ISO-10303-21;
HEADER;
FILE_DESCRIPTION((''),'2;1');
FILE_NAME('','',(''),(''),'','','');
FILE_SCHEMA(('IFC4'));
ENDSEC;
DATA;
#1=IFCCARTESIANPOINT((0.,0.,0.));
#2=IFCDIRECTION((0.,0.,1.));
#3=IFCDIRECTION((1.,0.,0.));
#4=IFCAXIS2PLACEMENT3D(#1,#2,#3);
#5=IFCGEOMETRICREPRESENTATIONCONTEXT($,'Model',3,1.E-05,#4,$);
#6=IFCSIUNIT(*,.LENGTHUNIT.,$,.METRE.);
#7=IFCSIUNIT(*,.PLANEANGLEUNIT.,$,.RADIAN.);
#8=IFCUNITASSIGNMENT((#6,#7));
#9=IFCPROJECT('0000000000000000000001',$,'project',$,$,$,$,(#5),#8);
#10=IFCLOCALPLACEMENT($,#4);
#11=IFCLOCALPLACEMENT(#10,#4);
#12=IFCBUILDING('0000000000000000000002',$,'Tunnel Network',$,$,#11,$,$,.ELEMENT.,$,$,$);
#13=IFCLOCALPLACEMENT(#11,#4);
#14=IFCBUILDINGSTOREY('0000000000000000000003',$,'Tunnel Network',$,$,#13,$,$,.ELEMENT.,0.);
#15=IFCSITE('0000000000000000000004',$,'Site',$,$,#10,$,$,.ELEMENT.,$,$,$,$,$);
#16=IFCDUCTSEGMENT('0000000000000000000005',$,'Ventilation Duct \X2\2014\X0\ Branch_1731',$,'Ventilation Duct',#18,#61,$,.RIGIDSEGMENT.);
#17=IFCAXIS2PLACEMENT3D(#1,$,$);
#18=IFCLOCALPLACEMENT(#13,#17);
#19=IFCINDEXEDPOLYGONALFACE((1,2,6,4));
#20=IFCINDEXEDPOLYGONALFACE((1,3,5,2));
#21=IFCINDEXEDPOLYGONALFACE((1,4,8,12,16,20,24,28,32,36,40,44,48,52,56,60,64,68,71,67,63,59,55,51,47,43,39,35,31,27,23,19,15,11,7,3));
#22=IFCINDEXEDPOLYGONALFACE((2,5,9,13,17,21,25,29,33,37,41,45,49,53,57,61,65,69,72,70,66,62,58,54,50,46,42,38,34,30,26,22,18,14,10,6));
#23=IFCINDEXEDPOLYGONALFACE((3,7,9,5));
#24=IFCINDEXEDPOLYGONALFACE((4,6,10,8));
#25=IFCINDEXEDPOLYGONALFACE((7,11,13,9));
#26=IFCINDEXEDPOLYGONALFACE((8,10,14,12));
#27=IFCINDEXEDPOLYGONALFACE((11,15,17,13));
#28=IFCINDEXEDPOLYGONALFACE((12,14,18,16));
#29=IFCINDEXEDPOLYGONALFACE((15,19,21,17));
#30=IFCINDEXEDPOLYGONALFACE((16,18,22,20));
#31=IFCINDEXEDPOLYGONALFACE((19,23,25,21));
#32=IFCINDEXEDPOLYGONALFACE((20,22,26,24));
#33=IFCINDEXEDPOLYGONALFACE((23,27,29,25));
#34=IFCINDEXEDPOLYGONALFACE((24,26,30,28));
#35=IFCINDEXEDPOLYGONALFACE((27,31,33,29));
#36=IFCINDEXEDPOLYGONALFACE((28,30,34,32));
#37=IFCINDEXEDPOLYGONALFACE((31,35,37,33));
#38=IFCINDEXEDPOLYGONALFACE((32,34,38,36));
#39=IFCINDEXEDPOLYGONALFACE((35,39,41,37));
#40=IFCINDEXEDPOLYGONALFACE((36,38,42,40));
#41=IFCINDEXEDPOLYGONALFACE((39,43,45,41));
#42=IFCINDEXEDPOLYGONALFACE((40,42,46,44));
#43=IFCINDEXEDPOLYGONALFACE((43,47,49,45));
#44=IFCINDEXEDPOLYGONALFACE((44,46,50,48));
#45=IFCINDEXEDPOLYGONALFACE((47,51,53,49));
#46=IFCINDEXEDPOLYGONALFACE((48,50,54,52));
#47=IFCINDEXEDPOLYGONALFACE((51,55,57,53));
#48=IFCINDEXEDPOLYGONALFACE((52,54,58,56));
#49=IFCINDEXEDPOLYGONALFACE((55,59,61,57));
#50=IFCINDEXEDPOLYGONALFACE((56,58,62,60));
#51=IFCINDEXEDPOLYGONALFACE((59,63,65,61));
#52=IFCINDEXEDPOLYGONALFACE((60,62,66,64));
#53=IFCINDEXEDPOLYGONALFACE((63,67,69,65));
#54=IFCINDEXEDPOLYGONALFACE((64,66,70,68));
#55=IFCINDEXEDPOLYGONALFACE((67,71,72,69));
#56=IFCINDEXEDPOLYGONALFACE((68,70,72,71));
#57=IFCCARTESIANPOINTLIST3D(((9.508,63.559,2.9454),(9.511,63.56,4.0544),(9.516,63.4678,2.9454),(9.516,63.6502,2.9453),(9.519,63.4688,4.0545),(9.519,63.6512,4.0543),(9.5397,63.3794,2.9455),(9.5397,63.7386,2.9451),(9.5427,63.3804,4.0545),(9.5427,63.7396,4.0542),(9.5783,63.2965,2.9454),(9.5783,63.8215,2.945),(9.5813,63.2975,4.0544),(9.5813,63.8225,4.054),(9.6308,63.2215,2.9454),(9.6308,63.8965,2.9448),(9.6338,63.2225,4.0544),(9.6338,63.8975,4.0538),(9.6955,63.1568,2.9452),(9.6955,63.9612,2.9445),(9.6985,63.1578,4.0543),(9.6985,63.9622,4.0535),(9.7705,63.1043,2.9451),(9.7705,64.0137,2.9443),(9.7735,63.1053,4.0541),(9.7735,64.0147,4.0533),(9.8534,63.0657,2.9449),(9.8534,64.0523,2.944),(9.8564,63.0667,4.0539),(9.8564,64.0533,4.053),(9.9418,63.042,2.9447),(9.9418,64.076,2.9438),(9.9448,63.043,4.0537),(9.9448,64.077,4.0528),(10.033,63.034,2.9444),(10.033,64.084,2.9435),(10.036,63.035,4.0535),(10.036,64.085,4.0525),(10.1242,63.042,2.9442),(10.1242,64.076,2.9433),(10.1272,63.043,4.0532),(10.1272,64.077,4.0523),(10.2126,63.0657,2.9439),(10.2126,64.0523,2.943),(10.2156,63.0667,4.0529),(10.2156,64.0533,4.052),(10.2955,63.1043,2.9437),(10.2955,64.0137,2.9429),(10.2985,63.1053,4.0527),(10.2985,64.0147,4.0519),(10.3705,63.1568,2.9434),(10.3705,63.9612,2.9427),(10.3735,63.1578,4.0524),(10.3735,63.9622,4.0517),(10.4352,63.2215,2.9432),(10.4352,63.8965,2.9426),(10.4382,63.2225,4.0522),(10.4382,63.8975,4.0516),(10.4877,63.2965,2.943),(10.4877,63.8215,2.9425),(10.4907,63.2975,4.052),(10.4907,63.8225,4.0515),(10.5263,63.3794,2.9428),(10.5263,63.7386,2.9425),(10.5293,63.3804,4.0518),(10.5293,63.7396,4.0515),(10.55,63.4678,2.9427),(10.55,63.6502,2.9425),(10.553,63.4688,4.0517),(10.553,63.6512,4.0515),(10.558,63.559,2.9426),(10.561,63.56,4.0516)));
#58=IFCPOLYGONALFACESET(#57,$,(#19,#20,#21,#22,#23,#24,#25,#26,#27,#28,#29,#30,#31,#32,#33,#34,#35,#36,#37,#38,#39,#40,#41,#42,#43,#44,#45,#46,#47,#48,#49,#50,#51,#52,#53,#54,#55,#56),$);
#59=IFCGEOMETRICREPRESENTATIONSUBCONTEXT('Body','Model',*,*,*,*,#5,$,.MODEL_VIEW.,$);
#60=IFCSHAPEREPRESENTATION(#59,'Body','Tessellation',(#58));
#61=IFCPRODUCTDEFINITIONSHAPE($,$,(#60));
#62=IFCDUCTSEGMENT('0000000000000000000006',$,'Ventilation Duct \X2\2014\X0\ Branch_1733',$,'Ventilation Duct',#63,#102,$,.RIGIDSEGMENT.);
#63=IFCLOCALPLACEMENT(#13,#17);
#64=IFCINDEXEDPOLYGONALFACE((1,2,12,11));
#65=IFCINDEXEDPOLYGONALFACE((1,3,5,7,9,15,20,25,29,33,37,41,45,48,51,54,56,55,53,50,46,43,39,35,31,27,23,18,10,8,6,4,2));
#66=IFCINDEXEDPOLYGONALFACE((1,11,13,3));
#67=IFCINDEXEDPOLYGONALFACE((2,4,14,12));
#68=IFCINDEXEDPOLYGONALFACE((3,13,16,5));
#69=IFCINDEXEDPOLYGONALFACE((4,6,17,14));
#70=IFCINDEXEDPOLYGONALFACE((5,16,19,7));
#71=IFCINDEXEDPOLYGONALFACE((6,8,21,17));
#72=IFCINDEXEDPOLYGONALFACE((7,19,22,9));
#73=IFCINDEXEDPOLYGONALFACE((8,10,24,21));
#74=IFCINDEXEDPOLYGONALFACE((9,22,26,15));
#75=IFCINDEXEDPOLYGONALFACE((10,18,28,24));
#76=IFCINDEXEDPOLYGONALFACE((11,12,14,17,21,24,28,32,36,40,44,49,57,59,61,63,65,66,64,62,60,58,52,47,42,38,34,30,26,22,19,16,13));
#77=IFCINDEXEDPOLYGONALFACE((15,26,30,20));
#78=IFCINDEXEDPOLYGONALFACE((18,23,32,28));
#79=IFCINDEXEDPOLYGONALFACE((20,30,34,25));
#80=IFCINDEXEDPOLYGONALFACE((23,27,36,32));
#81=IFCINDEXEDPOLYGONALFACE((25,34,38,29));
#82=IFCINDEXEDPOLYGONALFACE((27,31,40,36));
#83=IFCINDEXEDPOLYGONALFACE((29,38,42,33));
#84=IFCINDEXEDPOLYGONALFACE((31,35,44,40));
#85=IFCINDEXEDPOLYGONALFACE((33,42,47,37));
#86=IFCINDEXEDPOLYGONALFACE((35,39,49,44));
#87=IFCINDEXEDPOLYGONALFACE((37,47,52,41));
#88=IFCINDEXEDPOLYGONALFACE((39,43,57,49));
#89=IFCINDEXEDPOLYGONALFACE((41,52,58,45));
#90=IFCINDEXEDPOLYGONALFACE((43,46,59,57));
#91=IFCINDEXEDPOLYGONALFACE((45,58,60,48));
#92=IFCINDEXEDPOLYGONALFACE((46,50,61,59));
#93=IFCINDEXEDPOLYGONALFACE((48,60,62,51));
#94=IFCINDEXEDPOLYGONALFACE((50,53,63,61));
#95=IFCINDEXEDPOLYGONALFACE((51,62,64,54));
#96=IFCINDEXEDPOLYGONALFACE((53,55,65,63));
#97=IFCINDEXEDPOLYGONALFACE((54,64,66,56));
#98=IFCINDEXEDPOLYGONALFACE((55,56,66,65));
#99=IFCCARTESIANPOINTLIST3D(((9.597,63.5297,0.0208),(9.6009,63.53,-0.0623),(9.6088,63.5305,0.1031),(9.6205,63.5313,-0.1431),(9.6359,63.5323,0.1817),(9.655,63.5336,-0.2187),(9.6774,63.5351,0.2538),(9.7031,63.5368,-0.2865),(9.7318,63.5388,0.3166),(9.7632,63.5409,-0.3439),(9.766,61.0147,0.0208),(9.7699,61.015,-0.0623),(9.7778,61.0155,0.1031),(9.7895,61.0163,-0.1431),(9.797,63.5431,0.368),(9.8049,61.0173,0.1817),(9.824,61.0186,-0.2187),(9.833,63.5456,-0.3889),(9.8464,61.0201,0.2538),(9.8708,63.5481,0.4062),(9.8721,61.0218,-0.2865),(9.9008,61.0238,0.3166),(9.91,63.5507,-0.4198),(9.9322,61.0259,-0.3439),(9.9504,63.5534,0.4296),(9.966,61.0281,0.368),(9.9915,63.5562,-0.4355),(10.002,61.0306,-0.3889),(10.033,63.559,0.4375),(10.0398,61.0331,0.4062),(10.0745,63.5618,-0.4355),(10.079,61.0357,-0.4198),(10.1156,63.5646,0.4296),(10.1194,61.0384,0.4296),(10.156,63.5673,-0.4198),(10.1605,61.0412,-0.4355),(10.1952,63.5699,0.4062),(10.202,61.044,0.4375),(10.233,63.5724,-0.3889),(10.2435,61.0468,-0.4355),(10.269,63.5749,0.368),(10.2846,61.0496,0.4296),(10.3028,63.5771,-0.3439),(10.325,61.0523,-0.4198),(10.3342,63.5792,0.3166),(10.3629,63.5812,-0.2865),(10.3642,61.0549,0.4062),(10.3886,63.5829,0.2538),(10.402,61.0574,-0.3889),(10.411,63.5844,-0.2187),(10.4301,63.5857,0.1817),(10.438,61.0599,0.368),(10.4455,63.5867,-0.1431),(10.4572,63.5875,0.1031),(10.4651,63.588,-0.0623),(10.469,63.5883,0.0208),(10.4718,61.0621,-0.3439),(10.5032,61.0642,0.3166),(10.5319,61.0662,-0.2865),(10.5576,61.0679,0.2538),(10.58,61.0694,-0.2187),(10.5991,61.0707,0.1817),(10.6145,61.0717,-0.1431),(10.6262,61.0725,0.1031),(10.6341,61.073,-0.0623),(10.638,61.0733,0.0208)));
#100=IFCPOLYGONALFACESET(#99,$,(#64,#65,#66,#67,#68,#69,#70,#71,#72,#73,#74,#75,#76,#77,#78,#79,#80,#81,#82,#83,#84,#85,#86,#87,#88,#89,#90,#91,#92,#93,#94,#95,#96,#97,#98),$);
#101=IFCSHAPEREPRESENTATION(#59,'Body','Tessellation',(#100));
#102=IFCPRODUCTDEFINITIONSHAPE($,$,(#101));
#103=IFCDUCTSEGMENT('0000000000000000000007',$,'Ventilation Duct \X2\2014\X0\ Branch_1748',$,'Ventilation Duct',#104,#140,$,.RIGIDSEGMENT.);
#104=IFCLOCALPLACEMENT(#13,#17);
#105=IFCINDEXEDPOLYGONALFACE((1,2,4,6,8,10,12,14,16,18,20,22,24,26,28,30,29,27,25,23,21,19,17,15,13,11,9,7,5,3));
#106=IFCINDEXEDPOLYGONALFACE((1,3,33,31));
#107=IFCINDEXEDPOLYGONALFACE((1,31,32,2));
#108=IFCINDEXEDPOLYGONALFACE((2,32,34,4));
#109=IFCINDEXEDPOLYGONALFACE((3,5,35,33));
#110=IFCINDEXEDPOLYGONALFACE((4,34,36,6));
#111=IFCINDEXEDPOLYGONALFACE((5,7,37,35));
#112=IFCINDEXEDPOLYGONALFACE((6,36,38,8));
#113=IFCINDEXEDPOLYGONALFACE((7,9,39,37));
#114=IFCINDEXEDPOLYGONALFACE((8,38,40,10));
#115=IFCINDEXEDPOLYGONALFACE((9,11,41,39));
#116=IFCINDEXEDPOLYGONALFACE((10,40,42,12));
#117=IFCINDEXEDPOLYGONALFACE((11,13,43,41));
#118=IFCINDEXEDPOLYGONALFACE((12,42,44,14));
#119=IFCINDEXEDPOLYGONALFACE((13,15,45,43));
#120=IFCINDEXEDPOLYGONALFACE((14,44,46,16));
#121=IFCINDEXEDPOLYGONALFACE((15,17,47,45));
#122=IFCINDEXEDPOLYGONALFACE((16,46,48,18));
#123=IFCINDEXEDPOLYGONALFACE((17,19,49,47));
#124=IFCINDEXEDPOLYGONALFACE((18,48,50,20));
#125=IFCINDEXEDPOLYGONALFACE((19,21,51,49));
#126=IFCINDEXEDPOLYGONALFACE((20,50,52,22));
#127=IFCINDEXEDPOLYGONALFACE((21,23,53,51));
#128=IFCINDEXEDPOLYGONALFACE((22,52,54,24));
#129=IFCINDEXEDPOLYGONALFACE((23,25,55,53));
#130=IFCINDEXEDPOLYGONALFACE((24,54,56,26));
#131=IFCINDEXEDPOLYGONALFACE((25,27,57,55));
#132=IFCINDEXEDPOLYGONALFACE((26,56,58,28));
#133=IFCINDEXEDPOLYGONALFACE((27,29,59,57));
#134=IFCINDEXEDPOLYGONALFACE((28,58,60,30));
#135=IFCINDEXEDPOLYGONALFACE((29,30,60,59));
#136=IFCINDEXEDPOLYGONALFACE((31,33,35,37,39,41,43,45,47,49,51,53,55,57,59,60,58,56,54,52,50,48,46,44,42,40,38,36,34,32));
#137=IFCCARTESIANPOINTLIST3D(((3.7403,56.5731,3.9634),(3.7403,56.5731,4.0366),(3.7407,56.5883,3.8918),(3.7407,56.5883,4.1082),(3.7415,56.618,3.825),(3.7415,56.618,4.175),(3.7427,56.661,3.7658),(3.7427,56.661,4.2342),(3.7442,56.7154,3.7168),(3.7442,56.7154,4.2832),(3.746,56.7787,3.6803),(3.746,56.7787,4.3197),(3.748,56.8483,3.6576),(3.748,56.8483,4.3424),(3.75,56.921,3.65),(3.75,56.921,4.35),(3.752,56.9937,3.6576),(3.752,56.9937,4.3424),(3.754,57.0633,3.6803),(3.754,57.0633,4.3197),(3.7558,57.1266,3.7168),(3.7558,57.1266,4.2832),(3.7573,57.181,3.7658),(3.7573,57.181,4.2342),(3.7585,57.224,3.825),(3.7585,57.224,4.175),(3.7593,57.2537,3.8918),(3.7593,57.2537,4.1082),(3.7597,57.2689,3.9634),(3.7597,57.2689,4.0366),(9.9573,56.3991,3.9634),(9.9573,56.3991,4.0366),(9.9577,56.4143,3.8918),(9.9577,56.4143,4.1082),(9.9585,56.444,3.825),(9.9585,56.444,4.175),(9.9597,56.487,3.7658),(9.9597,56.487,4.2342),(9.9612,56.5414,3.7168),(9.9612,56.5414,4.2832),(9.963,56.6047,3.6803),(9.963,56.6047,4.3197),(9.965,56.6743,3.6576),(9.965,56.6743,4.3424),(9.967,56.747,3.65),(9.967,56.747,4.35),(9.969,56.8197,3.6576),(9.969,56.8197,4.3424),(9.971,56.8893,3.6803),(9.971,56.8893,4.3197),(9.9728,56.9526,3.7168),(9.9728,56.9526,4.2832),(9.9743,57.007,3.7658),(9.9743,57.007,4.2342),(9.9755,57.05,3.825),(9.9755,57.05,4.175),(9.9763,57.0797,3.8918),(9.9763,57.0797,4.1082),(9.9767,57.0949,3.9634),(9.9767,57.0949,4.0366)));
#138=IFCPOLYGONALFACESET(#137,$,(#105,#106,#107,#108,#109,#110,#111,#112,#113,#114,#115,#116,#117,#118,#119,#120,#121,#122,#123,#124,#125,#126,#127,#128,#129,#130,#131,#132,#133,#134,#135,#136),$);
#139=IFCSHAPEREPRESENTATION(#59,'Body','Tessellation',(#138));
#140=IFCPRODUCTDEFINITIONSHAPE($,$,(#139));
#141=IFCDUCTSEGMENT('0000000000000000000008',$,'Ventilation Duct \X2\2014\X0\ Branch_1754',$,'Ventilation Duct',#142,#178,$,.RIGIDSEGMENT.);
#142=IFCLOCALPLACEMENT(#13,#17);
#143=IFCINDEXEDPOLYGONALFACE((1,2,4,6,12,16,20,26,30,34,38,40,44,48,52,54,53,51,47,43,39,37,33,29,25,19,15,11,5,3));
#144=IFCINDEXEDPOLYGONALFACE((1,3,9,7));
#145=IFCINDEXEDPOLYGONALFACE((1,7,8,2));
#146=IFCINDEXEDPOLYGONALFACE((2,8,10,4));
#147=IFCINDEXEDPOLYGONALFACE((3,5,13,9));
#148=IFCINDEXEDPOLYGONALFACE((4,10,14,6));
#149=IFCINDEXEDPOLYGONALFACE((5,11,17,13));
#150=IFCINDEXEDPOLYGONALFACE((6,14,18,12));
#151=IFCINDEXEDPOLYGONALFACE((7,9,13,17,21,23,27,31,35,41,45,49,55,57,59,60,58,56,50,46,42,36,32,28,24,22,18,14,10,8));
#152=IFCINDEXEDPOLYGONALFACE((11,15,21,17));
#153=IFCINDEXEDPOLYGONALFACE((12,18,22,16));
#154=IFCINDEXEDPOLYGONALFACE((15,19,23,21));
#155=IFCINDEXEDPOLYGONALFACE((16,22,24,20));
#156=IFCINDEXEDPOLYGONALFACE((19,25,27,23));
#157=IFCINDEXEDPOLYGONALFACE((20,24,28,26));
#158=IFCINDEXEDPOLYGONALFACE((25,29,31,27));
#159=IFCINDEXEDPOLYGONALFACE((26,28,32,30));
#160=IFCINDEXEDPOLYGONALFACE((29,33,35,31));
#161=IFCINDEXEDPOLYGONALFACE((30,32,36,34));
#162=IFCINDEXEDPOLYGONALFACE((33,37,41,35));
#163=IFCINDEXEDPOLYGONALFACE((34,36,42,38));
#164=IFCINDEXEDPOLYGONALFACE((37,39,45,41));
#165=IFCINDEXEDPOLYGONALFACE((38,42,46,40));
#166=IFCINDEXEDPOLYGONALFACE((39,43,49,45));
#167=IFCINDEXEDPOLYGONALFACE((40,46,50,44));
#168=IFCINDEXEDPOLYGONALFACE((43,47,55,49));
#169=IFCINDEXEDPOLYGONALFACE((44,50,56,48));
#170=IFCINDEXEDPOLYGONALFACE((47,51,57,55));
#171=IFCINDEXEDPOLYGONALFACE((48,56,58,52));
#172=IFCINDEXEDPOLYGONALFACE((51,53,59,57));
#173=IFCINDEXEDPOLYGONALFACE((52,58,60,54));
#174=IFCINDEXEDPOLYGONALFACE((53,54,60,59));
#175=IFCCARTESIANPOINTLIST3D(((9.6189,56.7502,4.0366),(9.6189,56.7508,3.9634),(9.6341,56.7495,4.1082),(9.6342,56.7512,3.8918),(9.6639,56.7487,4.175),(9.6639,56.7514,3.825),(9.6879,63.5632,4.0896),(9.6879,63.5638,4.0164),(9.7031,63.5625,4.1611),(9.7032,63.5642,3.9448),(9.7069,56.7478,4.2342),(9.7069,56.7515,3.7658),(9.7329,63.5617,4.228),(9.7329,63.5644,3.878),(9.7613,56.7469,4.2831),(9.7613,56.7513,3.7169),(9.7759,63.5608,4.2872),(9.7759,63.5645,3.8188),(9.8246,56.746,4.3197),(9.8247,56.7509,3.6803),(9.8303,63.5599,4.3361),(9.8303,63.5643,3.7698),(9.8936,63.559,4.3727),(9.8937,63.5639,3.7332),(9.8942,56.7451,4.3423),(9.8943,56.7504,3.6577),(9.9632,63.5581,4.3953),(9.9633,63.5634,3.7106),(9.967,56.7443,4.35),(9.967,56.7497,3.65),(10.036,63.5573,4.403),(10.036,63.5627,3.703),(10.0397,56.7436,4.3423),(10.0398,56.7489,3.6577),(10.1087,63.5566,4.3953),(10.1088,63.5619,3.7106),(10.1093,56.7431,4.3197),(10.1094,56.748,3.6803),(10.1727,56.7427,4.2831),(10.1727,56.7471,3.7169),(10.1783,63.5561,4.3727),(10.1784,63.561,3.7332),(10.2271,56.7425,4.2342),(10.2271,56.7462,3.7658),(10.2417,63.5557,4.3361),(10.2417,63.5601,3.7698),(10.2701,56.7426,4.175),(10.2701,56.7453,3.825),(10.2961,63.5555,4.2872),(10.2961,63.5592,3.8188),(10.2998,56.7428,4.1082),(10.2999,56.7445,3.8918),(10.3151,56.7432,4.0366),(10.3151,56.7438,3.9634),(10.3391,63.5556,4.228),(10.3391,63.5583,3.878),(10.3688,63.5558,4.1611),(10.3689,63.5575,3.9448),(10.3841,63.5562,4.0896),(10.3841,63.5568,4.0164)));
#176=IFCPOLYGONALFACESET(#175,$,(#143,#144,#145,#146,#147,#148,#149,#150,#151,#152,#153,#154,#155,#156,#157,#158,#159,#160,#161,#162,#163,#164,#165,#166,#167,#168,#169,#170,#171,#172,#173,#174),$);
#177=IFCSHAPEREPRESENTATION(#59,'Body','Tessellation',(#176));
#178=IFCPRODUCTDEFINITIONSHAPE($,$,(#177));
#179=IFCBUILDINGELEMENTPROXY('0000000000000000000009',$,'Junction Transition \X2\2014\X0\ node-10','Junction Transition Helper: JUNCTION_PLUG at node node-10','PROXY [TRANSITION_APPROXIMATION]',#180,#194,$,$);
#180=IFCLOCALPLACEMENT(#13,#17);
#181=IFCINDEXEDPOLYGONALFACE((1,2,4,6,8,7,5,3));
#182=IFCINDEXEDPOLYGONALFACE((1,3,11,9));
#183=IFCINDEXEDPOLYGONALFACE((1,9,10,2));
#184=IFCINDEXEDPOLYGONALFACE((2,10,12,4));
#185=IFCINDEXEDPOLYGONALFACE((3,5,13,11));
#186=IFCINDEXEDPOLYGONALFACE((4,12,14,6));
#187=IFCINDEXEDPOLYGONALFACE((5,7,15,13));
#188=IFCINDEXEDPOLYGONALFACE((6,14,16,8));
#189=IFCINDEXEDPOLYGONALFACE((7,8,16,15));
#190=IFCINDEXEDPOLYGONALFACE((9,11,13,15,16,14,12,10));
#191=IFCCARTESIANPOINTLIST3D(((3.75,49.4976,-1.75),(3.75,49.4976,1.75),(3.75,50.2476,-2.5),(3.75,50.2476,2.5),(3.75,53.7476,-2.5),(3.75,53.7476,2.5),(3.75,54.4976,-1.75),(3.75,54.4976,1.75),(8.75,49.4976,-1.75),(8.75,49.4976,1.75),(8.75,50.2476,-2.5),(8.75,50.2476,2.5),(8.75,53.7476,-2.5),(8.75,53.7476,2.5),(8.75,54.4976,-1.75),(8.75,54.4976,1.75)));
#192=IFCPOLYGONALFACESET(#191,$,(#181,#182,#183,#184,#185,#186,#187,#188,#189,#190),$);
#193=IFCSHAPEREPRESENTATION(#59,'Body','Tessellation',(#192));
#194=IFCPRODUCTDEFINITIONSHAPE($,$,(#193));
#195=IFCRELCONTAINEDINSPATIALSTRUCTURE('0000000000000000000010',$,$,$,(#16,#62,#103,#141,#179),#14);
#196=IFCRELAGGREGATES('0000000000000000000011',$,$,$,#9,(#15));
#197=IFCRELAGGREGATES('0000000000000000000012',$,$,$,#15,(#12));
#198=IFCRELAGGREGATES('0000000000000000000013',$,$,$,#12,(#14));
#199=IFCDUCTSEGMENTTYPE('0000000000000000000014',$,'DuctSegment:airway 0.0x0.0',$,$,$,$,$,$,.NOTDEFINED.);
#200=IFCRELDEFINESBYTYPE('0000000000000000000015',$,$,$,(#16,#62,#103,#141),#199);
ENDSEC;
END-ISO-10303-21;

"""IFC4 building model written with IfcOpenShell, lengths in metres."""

from ifc_helpers import new_model, si_unit, frame, origin_with_axes, origin_2d_with_axis, place, context, subcontext, project, spatial, polyline, circle, outline, extrude, type_object, element, save


model = new_model("IFC4")

# Units and contexts
model_context = context("Model", 3, precision=1e-05, world=origin_with_axes())
body_context = subcontext(model_context, "Body", "Model", "MODEL_VIEW")
ifc_project = project(units=[si_unit("LENGTHUNIT", "METRE"), si_unit("PLANEANGLEUNIT", "RADIAN")], contexts=[model_context])

# Site, building, storey
site_placement = place(None, origin_with_axes())
site = spatial("IfcSite", under=ifc_project, at=site_placement, Name="Site", CompositionType="ELEMENT")
building_placement = place(site_placement, origin_with_axes())
building = spatial("IfcBuilding", under=site, at=building_placement, Name="Tunnel Network", CompositionType="ELEMENT")
storey_placement = place(building_placement, origin_with_axes())
storey = spatial("IfcBuildingStorey", under=building, at=storey_placement, Name="Tunnel Network", CompositionType="ELEMENT", Elevation=0.0)

# Duct segments
duct_segment_type_1 = type_object("IfcDuctSegmentType", Name="DuctSegment:airway 0.0x0.0")
duct_segment_1_placement = place(storey_placement, frame((10.033, 63.559, 2.944), z_axis=(0.002704, 0.000901, 0.999996), x_axis=(0.999996, -0.000002, -0.002704)))
element("IfcDuctSegment", 1, at=duct_segment_1_placement, inside=storey, type_object=duct_segment_type_1, Name="Ventilation Duct — Branch_1731", ObjectType="Ventilation Duct", PredefinedType="RIGIDSEGMENT", context=body_context, shape_type="SweptSolid", body=[
    extrude(circle(Radius=0.525, at=origin_2d_with_axis()), origin_with_axes(), (0.0, 0.0, 1.0), 1.109),
])
duct_segment_2_placement = place(storey_placement, frame((10.202, 61.044, 0.0), z_axis=(-0.067045, 0.99775, 0.0), x_axis=(0.0, 0.0, 1.0)))
element("IfcDuctSegment", 2, at=duct_segment_2_placement, inside=storey, type_object=duct_segment_type_1, Name="Ventilation Duct — Branch_1733", ObjectType="Ventilation Duct", PredefinedType="RIGIDSEGMENT", context=body_context, shape_type="SweptSolid", body=[
    extrude(circle(Radius=0.4375, at=origin_2d_with_axis()), origin_with_axes(), (0.0, 0.0, 1.0), 2.5207),
])
duct_segment_3_placement = place(storey_placement, frame((3.75, 56.921, 4.0), z_axis=(0.999609, -0.027977, 0.0), x_axis=(0.0, 0.0, 1.0)))
element("IfcDuctSegment", 3, at=duct_segment_3_placement, inside=storey, type_object=duct_segment_type_1, Name="Ventilation Duct — Branch_1748", ObjectType="Ventilation Duct", PredefinedType="RIGIDSEGMENT", context=body_context, shape_type="SweptSolid", body=[
    extrude(circle(Radius=0.35, at=origin_2d_with_axis()), origin_with_axes(), (0.0, 0.0, 1.0), 6.2194),
])
duct_segment_4_placement = place(storey_placement, frame((9.967, 56.747, 4.0), z_axis=(0.010127, 0.999918, 0.007775), x_axis=(-0.000079, -0.007775, 0.99997)))
element("IfcDuctSegment", 4, at=duct_segment_4_placement, inside=storey, type_object=duct_segment_type_1, Name="Ventilation Duct — Branch_1754", ObjectType="Ventilation Duct", PredefinedType="RIGIDSEGMENT", context=body_context, shape_type="SweptSolid", body=[
    extrude(circle(Radius=0.35, at=origin_2d_with_axis()), origin_with_axes(), (0.0, 0.0, 1.0), 6.8136),
])

# Building element proxy
proxy_1_placement = place(storey_placement, frame((3.75, 51.9976, 0.0), z_axis=(1.0, 0.0, 0.0), x_axis=(0.0, -1.0, 0.0)))
element("IfcBuildingElementProxy", 5, at=proxy_1_placement, inside=storey, Name="Junction Transition — node-10", Description="Junction Transition Helper: JUNCTION_PLUG at node node-10", ObjectType="PROXY [TRANSITION_APPROXIMATION]", context=body_context, shape_type="SweptSolid", body=[
    extrude(outline(polyline([(1.75, 2.5), (2.5, 1.75), (2.5, -1.75), (1.75, -2.5), (-1.75, -2.5), (-2.5, -1.75), (-2.5, 1.75), (-1.75, 2.5), (1.75, 2.5)])), origin_with_axes(), (0.0, 0.0, 1.0), 5.0),
])

save(model, "model.ifc")
